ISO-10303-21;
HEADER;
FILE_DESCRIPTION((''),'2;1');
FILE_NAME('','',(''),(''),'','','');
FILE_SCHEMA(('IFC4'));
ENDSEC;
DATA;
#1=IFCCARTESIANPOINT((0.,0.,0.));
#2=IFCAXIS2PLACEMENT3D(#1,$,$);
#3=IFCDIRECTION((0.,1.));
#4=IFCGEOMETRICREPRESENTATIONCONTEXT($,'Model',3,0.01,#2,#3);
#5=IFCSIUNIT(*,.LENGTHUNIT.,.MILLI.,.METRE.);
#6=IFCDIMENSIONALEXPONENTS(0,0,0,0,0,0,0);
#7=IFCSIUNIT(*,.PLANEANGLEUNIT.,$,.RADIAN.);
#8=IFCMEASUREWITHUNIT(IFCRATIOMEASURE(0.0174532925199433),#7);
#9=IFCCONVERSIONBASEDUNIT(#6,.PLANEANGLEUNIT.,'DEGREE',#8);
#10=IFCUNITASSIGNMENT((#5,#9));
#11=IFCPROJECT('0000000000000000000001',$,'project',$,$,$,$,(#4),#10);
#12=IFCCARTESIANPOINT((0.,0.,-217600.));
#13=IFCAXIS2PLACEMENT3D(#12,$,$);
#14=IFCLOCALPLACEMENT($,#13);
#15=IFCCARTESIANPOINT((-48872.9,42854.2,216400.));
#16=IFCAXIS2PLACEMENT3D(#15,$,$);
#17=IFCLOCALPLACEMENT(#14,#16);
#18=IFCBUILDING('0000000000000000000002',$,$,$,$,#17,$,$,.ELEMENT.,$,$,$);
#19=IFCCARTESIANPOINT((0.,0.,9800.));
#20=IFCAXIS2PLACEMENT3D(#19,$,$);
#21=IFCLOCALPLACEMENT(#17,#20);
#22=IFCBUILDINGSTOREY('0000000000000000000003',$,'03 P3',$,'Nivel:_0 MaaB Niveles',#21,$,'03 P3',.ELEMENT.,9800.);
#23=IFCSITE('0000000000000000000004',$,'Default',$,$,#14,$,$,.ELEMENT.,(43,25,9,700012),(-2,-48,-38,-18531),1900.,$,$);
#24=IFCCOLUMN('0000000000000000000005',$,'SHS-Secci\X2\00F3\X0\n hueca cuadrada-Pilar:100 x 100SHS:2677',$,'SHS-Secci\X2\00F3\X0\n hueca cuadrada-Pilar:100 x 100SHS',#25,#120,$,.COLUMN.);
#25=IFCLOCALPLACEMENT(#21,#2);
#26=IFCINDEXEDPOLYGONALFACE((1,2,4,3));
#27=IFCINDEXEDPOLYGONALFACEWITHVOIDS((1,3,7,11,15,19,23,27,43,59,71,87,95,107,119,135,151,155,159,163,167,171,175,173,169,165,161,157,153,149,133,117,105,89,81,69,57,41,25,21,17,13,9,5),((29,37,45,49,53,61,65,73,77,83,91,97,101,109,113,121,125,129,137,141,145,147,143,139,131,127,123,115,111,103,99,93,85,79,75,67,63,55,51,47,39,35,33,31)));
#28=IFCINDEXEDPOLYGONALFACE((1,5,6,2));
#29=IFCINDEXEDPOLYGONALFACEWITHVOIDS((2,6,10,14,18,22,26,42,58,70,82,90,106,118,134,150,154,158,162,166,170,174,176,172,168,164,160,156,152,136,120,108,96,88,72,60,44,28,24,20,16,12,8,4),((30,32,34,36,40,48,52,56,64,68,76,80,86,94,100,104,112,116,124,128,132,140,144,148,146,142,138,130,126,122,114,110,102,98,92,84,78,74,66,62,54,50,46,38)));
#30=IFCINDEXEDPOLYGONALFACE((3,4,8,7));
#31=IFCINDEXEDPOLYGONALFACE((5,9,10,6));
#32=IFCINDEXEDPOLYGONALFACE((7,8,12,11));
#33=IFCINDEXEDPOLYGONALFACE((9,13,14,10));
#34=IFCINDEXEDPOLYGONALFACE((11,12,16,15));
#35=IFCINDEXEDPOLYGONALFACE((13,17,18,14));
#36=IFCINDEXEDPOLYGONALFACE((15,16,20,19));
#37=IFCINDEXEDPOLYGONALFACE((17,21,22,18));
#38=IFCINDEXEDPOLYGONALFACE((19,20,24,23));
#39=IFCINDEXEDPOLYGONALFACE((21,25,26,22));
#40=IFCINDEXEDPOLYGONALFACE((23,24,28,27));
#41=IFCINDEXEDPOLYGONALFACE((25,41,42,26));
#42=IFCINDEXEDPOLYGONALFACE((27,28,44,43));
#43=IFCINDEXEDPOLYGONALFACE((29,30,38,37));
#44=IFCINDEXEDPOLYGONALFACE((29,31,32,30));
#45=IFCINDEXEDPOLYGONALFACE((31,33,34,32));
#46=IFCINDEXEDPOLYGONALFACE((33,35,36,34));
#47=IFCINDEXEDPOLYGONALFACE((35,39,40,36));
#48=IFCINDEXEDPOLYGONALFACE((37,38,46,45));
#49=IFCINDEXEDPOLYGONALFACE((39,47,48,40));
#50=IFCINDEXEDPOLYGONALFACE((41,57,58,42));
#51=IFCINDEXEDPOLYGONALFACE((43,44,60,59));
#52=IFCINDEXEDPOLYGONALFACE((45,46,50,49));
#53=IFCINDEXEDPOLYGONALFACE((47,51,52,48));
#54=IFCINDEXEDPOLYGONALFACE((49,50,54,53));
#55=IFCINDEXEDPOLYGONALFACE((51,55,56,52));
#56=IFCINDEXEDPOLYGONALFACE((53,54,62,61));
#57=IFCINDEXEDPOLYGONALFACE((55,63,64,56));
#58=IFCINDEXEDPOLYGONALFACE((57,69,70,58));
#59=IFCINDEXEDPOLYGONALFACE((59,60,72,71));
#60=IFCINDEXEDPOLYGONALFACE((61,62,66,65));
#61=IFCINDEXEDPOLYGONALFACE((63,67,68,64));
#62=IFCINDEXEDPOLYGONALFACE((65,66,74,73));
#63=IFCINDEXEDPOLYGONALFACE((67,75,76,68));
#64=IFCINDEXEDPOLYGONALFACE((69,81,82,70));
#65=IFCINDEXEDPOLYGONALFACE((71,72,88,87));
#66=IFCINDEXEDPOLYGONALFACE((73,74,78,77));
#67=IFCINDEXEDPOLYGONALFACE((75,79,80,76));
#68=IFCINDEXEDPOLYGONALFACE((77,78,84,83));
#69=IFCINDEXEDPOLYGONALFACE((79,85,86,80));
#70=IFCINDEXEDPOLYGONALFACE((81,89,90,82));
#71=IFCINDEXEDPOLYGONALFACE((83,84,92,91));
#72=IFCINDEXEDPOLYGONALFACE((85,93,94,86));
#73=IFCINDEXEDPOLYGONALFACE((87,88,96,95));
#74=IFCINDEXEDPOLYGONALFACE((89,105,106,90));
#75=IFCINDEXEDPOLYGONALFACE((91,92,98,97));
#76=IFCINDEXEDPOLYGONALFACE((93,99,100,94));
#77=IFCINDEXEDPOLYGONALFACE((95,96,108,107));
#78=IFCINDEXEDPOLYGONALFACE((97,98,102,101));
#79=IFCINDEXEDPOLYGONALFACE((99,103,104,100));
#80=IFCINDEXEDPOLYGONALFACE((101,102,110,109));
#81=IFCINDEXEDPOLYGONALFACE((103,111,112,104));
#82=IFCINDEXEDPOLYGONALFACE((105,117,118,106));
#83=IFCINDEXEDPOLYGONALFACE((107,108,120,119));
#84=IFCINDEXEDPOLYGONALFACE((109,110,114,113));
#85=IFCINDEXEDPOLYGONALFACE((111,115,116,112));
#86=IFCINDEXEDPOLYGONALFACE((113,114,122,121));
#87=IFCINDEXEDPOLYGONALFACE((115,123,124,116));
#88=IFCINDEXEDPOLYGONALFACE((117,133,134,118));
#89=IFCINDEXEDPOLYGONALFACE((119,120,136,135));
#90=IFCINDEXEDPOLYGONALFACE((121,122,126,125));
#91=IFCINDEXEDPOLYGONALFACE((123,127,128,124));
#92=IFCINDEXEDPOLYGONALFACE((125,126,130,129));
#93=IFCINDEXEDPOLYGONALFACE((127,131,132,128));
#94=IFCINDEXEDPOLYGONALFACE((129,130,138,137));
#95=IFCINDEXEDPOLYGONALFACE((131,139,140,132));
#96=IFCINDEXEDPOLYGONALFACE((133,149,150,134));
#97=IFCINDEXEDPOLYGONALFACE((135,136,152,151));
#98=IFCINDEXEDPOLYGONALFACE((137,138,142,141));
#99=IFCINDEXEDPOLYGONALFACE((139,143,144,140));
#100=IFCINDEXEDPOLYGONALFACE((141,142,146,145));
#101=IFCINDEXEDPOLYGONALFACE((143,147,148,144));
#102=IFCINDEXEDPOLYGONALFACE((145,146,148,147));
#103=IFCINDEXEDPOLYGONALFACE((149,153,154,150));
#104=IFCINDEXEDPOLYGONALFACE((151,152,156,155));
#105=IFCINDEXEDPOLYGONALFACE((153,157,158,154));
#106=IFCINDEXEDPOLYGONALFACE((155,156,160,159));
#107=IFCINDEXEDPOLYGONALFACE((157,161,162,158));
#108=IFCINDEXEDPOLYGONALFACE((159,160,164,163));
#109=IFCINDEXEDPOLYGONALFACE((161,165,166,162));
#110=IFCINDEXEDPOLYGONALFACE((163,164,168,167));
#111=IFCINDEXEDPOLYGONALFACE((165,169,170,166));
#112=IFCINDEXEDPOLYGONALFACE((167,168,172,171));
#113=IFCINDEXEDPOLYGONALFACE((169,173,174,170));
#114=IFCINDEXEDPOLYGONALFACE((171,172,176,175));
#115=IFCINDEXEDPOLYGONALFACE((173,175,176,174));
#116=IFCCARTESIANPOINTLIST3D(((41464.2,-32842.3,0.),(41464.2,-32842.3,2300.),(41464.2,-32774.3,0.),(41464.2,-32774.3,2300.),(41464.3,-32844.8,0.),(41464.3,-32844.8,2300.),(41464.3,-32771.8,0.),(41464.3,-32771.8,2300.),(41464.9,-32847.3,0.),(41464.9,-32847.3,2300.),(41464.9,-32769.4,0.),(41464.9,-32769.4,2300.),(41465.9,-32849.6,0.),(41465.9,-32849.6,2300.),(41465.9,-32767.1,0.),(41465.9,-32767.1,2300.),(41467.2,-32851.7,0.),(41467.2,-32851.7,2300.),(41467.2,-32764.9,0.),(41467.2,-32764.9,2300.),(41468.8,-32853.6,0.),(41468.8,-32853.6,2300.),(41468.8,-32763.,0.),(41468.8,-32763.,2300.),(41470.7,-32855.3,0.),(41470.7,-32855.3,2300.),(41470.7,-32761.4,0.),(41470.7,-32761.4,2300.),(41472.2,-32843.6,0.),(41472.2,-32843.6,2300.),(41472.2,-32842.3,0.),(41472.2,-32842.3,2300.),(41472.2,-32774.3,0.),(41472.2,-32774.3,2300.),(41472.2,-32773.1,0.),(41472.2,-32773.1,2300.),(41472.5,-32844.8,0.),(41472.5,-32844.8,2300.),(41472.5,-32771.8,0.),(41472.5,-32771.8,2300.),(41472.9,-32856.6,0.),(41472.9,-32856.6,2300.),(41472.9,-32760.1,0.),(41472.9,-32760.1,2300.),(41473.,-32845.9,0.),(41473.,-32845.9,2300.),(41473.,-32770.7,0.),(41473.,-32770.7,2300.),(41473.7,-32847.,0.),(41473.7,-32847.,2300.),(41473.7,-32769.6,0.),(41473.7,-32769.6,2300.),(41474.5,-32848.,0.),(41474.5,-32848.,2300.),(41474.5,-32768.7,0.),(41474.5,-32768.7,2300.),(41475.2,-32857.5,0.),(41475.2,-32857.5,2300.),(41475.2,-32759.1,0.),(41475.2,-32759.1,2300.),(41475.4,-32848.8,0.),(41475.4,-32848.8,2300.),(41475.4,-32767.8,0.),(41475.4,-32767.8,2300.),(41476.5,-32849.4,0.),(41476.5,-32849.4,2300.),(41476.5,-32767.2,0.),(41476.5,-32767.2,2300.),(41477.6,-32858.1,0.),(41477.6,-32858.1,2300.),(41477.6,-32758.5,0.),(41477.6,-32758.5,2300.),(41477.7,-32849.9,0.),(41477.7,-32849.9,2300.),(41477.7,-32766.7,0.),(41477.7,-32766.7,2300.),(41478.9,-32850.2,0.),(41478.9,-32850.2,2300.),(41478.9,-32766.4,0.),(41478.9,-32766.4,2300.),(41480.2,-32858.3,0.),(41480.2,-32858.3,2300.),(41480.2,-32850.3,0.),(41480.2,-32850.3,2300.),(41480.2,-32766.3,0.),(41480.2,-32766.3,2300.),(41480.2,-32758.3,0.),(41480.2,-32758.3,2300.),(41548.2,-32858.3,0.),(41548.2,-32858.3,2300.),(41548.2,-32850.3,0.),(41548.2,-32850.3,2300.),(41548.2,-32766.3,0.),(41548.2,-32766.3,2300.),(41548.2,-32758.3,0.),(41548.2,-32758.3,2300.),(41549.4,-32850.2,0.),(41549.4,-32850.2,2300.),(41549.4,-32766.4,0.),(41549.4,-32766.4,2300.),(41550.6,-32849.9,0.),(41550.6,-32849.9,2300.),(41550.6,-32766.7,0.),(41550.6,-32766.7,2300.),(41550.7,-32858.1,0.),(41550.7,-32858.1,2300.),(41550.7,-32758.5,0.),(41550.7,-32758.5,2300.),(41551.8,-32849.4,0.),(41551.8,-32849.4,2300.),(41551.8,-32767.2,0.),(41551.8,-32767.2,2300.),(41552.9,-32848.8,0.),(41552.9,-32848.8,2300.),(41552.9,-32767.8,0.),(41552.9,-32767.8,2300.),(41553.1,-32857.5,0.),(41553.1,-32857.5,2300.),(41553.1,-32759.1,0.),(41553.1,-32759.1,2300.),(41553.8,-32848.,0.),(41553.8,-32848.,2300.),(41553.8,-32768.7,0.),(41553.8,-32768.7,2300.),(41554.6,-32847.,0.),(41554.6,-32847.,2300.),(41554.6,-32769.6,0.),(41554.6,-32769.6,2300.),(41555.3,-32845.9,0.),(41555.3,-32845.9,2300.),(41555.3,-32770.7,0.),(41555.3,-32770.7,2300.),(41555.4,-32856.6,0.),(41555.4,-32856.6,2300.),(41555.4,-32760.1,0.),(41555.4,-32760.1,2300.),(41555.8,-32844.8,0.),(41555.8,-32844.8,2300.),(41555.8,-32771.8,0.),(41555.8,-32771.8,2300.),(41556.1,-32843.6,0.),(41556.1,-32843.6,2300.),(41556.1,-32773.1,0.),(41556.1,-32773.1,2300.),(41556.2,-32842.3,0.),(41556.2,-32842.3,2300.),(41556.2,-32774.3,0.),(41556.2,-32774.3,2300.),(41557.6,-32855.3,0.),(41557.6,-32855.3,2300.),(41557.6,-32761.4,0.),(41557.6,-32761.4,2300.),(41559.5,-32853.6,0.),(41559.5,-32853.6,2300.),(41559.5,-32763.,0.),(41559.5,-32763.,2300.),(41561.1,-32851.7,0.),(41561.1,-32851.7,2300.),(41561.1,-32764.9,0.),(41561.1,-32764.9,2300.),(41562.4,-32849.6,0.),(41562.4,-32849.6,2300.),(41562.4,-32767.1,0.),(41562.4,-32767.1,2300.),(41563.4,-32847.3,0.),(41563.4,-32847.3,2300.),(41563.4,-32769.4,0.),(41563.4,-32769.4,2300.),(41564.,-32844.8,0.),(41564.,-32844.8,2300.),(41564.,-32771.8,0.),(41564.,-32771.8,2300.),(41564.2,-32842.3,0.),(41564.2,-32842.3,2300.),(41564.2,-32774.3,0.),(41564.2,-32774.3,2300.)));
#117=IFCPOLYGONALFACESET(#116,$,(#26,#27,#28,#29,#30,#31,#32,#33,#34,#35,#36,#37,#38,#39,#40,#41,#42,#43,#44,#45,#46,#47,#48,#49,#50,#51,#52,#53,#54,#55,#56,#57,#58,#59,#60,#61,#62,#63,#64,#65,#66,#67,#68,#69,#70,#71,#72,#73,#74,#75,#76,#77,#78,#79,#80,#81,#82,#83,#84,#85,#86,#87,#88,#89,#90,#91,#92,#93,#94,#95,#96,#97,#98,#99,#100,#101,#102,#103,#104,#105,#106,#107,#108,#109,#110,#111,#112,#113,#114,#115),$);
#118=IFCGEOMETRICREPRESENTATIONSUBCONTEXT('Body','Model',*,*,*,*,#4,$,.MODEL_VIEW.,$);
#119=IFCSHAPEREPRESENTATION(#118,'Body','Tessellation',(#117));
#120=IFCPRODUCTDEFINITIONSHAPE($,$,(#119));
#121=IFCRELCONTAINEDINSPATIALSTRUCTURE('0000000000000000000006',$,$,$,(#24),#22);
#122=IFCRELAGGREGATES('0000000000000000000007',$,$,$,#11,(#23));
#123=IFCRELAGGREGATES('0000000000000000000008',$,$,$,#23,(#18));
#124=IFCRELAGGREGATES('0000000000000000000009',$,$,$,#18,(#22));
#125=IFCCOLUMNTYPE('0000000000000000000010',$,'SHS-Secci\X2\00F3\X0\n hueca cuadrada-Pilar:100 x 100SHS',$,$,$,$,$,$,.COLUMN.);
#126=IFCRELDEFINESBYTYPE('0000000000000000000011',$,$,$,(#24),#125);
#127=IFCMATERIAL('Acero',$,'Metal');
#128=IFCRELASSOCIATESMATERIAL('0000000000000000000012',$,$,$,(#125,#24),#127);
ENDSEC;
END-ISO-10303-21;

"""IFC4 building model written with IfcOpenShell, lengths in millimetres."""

from ifc_helpers import new_model, entity, si_unit, converted_unit, direction, frame, origin, place, context, subcontext, project, spatial, indexed_curve, outline, extrude, source, transform, mapped, material, type_object, type_shapes, element, save


model = new_model("IFC4")

# Units and contexts
model_context = context("Model", 3, precision=0.01, world=origin(), true_north=direction((0.0, 1.0)))
body_context = subcontext(model_context, "Body", "Model", "MODEL_VIEW")
ifc_project = project(units=[si_unit("LENGTHUNIT", "METRE", prefix="MILLI"), converted_unit("PLANEANGLEUNIT", "DEGREE", entity("IfcRatioMeasure", 0.0174532925199433), si_unit("PLANEANGLEUNIT", "RADIAN"), dimensions=[0, 0, 0, 0, 0, 0, 0])], contexts=[model_context])

# Site, building, storey
site_placement = place(None, frame((0.0, 0.0, -217600.0)))
site = spatial("IfcSite", under=ifc_project, at=site_placement, Name="Default", CompositionType="ELEMENT", RefLatitude=(43, 25, 9, 700012), RefLongitude=(-2, -48, -38, -18531), RefElevation=1900.0)
building_placement = place(site_placement, frame((-48872.9, 42854.2, 216400.0)))
building = spatial("IfcBuilding", under=site, at=building_placement, CompositionType="ELEMENT")
storey_placement = place(building_placement, frame((0.0, 0.0, 9800.0)))
storey = spatial("IfcBuildingStorey", under=building, at=storey_placement, Name="03 P3", ObjectType="Nivel:_0 MaaB Niveles", LongName="03 P3", CompositionType="ELEMENT", Elevation=9800.0)

# Column
ifc_material_1 = material(Name="Acero", Category="Metal")
column_type_1 = type_object("IfcColumnType", Name="SHS-Sección hueca cuadrada-Pilar:100 x 100SHS", PredefinedType="COLUMN", material=ifc_material_1)
shared_shape_1 = source(origin(), body_context, "Body", "SweptSolid", [
    extrude(outline(indexed_curve([(-34.0, -50.0), (34.0, -50.0), (36.5, -49.8), (38.9, -49.2), (41.3, -48.3), (43.4, -46.9), (45.3, -45.3), (46.9, -43.4), (48.3, -41.3), (49.2, -38.9), (49.8, -36.5), (50.0, -34.0), (50.0, 34.0), (49.8, 36.5), (49.2, 38.9), (48.3, 41.3), (46.9, 43.4), (45.3, 45.3), (43.4, 46.9), (41.3, 48.3), (38.9, 49.2), (36.5, 49.8), (34.0, 50.0), (-34.0, 50.0), (-36.5, 49.8), (-38.9, 49.2), (-41.3, 48.3), (-43.4, 46.9), (-45.3, 45.3), (-46.9, 43.4), (-48.3, 41.3), (-49.2, 38.9), (-49.8, 36.5), (-50.0, 34.0), (-50.0, -34.0), (-49.8, -36.5), (-49.2, -38.9), (-48.3, -41.3), (-46.9, -43.4), (-45.3, -45.3), (-43.4, -46.9), (-41.3, -48.3), (-38.9, -49.2), (-36.5, -49.8), (-34.0, -50.0)], self_intersect=False), holes=[indexed_curve([(-42.0, 34.0), (-41.9, 35.3), (-41.6, 36.5), (-41.1, 37.6), (-40.5, 38.7), (-39.7, 39.7), (-38.7, 40.5), (-37.6, 41.1), (-36.5, 41.6), (-35.3, 41.9), (-34.0, 42.0), (34.0, 42.0), (35.3, 41.9), (36.5, 41.6), (37.6, 41.1), (38.7, 40.5), (39.7, 39.7), (40.5, 38.7), (41.1, 37.6), (41.6, 36.5), (41.9, 35.3), (42.0, 34.0), (42.0, -34.0), (41.9, -35.3), (41.6, -36.5), (41.1, -37.6), (40.5, -38.7), (39.7, -39.7), (38.7, -40.5), (37.6, -41.1), (36.5, -41.6), (35.3, -41.9), (34.0, -42.0), (-34.0, -42.0), (-35.3, -41.9), (-36.5, -41.6), (-37.6, -41.1), (-38.7, -40.5), (-39.7, -39.7), (-40.5, -38.7), (-41.1, -37.6), (-41.6, -36.5), (-41.9, -35.3), (-42.0, -34.0), (-42.0, 34.0)], self_intersect=False)]), frame((0.0, 0.0, 9800.0), z_axis=(0.0, 0.0, 1.0), x_axis=(0.0, 1.0, 0.0)), (0.0, 0.0, 1.0), 2300.0),
])
type_shapes(column_type_1, [shared_shape_1])
column_1_placement = place(storey_placement, frame((41514.2, -32808.3, -9800.0), z_axis=(0.0, 0.0, 1.0), x_axis=(0.0, -1.0, 0.0)))
element("IfcColumn", 1, at=column_1_placement, inside=storey, type_object=column_type_1, material=ifc_material_1, Name="SHS-Sección hueca cuadrada-Pilar:100 x 100SHS:2677", ObjectType="SHS-Sección hueca cuadrada-Pilar:100 x 100SHS", PredefinedType="COLUMN", context=body_context, shape_type="MappedRepresentation", body=[
    mapped(shared_shape_1, transform((0.0, 0.0, 0.0), scale=1.0)),
])

save(model, "model.ifc")
